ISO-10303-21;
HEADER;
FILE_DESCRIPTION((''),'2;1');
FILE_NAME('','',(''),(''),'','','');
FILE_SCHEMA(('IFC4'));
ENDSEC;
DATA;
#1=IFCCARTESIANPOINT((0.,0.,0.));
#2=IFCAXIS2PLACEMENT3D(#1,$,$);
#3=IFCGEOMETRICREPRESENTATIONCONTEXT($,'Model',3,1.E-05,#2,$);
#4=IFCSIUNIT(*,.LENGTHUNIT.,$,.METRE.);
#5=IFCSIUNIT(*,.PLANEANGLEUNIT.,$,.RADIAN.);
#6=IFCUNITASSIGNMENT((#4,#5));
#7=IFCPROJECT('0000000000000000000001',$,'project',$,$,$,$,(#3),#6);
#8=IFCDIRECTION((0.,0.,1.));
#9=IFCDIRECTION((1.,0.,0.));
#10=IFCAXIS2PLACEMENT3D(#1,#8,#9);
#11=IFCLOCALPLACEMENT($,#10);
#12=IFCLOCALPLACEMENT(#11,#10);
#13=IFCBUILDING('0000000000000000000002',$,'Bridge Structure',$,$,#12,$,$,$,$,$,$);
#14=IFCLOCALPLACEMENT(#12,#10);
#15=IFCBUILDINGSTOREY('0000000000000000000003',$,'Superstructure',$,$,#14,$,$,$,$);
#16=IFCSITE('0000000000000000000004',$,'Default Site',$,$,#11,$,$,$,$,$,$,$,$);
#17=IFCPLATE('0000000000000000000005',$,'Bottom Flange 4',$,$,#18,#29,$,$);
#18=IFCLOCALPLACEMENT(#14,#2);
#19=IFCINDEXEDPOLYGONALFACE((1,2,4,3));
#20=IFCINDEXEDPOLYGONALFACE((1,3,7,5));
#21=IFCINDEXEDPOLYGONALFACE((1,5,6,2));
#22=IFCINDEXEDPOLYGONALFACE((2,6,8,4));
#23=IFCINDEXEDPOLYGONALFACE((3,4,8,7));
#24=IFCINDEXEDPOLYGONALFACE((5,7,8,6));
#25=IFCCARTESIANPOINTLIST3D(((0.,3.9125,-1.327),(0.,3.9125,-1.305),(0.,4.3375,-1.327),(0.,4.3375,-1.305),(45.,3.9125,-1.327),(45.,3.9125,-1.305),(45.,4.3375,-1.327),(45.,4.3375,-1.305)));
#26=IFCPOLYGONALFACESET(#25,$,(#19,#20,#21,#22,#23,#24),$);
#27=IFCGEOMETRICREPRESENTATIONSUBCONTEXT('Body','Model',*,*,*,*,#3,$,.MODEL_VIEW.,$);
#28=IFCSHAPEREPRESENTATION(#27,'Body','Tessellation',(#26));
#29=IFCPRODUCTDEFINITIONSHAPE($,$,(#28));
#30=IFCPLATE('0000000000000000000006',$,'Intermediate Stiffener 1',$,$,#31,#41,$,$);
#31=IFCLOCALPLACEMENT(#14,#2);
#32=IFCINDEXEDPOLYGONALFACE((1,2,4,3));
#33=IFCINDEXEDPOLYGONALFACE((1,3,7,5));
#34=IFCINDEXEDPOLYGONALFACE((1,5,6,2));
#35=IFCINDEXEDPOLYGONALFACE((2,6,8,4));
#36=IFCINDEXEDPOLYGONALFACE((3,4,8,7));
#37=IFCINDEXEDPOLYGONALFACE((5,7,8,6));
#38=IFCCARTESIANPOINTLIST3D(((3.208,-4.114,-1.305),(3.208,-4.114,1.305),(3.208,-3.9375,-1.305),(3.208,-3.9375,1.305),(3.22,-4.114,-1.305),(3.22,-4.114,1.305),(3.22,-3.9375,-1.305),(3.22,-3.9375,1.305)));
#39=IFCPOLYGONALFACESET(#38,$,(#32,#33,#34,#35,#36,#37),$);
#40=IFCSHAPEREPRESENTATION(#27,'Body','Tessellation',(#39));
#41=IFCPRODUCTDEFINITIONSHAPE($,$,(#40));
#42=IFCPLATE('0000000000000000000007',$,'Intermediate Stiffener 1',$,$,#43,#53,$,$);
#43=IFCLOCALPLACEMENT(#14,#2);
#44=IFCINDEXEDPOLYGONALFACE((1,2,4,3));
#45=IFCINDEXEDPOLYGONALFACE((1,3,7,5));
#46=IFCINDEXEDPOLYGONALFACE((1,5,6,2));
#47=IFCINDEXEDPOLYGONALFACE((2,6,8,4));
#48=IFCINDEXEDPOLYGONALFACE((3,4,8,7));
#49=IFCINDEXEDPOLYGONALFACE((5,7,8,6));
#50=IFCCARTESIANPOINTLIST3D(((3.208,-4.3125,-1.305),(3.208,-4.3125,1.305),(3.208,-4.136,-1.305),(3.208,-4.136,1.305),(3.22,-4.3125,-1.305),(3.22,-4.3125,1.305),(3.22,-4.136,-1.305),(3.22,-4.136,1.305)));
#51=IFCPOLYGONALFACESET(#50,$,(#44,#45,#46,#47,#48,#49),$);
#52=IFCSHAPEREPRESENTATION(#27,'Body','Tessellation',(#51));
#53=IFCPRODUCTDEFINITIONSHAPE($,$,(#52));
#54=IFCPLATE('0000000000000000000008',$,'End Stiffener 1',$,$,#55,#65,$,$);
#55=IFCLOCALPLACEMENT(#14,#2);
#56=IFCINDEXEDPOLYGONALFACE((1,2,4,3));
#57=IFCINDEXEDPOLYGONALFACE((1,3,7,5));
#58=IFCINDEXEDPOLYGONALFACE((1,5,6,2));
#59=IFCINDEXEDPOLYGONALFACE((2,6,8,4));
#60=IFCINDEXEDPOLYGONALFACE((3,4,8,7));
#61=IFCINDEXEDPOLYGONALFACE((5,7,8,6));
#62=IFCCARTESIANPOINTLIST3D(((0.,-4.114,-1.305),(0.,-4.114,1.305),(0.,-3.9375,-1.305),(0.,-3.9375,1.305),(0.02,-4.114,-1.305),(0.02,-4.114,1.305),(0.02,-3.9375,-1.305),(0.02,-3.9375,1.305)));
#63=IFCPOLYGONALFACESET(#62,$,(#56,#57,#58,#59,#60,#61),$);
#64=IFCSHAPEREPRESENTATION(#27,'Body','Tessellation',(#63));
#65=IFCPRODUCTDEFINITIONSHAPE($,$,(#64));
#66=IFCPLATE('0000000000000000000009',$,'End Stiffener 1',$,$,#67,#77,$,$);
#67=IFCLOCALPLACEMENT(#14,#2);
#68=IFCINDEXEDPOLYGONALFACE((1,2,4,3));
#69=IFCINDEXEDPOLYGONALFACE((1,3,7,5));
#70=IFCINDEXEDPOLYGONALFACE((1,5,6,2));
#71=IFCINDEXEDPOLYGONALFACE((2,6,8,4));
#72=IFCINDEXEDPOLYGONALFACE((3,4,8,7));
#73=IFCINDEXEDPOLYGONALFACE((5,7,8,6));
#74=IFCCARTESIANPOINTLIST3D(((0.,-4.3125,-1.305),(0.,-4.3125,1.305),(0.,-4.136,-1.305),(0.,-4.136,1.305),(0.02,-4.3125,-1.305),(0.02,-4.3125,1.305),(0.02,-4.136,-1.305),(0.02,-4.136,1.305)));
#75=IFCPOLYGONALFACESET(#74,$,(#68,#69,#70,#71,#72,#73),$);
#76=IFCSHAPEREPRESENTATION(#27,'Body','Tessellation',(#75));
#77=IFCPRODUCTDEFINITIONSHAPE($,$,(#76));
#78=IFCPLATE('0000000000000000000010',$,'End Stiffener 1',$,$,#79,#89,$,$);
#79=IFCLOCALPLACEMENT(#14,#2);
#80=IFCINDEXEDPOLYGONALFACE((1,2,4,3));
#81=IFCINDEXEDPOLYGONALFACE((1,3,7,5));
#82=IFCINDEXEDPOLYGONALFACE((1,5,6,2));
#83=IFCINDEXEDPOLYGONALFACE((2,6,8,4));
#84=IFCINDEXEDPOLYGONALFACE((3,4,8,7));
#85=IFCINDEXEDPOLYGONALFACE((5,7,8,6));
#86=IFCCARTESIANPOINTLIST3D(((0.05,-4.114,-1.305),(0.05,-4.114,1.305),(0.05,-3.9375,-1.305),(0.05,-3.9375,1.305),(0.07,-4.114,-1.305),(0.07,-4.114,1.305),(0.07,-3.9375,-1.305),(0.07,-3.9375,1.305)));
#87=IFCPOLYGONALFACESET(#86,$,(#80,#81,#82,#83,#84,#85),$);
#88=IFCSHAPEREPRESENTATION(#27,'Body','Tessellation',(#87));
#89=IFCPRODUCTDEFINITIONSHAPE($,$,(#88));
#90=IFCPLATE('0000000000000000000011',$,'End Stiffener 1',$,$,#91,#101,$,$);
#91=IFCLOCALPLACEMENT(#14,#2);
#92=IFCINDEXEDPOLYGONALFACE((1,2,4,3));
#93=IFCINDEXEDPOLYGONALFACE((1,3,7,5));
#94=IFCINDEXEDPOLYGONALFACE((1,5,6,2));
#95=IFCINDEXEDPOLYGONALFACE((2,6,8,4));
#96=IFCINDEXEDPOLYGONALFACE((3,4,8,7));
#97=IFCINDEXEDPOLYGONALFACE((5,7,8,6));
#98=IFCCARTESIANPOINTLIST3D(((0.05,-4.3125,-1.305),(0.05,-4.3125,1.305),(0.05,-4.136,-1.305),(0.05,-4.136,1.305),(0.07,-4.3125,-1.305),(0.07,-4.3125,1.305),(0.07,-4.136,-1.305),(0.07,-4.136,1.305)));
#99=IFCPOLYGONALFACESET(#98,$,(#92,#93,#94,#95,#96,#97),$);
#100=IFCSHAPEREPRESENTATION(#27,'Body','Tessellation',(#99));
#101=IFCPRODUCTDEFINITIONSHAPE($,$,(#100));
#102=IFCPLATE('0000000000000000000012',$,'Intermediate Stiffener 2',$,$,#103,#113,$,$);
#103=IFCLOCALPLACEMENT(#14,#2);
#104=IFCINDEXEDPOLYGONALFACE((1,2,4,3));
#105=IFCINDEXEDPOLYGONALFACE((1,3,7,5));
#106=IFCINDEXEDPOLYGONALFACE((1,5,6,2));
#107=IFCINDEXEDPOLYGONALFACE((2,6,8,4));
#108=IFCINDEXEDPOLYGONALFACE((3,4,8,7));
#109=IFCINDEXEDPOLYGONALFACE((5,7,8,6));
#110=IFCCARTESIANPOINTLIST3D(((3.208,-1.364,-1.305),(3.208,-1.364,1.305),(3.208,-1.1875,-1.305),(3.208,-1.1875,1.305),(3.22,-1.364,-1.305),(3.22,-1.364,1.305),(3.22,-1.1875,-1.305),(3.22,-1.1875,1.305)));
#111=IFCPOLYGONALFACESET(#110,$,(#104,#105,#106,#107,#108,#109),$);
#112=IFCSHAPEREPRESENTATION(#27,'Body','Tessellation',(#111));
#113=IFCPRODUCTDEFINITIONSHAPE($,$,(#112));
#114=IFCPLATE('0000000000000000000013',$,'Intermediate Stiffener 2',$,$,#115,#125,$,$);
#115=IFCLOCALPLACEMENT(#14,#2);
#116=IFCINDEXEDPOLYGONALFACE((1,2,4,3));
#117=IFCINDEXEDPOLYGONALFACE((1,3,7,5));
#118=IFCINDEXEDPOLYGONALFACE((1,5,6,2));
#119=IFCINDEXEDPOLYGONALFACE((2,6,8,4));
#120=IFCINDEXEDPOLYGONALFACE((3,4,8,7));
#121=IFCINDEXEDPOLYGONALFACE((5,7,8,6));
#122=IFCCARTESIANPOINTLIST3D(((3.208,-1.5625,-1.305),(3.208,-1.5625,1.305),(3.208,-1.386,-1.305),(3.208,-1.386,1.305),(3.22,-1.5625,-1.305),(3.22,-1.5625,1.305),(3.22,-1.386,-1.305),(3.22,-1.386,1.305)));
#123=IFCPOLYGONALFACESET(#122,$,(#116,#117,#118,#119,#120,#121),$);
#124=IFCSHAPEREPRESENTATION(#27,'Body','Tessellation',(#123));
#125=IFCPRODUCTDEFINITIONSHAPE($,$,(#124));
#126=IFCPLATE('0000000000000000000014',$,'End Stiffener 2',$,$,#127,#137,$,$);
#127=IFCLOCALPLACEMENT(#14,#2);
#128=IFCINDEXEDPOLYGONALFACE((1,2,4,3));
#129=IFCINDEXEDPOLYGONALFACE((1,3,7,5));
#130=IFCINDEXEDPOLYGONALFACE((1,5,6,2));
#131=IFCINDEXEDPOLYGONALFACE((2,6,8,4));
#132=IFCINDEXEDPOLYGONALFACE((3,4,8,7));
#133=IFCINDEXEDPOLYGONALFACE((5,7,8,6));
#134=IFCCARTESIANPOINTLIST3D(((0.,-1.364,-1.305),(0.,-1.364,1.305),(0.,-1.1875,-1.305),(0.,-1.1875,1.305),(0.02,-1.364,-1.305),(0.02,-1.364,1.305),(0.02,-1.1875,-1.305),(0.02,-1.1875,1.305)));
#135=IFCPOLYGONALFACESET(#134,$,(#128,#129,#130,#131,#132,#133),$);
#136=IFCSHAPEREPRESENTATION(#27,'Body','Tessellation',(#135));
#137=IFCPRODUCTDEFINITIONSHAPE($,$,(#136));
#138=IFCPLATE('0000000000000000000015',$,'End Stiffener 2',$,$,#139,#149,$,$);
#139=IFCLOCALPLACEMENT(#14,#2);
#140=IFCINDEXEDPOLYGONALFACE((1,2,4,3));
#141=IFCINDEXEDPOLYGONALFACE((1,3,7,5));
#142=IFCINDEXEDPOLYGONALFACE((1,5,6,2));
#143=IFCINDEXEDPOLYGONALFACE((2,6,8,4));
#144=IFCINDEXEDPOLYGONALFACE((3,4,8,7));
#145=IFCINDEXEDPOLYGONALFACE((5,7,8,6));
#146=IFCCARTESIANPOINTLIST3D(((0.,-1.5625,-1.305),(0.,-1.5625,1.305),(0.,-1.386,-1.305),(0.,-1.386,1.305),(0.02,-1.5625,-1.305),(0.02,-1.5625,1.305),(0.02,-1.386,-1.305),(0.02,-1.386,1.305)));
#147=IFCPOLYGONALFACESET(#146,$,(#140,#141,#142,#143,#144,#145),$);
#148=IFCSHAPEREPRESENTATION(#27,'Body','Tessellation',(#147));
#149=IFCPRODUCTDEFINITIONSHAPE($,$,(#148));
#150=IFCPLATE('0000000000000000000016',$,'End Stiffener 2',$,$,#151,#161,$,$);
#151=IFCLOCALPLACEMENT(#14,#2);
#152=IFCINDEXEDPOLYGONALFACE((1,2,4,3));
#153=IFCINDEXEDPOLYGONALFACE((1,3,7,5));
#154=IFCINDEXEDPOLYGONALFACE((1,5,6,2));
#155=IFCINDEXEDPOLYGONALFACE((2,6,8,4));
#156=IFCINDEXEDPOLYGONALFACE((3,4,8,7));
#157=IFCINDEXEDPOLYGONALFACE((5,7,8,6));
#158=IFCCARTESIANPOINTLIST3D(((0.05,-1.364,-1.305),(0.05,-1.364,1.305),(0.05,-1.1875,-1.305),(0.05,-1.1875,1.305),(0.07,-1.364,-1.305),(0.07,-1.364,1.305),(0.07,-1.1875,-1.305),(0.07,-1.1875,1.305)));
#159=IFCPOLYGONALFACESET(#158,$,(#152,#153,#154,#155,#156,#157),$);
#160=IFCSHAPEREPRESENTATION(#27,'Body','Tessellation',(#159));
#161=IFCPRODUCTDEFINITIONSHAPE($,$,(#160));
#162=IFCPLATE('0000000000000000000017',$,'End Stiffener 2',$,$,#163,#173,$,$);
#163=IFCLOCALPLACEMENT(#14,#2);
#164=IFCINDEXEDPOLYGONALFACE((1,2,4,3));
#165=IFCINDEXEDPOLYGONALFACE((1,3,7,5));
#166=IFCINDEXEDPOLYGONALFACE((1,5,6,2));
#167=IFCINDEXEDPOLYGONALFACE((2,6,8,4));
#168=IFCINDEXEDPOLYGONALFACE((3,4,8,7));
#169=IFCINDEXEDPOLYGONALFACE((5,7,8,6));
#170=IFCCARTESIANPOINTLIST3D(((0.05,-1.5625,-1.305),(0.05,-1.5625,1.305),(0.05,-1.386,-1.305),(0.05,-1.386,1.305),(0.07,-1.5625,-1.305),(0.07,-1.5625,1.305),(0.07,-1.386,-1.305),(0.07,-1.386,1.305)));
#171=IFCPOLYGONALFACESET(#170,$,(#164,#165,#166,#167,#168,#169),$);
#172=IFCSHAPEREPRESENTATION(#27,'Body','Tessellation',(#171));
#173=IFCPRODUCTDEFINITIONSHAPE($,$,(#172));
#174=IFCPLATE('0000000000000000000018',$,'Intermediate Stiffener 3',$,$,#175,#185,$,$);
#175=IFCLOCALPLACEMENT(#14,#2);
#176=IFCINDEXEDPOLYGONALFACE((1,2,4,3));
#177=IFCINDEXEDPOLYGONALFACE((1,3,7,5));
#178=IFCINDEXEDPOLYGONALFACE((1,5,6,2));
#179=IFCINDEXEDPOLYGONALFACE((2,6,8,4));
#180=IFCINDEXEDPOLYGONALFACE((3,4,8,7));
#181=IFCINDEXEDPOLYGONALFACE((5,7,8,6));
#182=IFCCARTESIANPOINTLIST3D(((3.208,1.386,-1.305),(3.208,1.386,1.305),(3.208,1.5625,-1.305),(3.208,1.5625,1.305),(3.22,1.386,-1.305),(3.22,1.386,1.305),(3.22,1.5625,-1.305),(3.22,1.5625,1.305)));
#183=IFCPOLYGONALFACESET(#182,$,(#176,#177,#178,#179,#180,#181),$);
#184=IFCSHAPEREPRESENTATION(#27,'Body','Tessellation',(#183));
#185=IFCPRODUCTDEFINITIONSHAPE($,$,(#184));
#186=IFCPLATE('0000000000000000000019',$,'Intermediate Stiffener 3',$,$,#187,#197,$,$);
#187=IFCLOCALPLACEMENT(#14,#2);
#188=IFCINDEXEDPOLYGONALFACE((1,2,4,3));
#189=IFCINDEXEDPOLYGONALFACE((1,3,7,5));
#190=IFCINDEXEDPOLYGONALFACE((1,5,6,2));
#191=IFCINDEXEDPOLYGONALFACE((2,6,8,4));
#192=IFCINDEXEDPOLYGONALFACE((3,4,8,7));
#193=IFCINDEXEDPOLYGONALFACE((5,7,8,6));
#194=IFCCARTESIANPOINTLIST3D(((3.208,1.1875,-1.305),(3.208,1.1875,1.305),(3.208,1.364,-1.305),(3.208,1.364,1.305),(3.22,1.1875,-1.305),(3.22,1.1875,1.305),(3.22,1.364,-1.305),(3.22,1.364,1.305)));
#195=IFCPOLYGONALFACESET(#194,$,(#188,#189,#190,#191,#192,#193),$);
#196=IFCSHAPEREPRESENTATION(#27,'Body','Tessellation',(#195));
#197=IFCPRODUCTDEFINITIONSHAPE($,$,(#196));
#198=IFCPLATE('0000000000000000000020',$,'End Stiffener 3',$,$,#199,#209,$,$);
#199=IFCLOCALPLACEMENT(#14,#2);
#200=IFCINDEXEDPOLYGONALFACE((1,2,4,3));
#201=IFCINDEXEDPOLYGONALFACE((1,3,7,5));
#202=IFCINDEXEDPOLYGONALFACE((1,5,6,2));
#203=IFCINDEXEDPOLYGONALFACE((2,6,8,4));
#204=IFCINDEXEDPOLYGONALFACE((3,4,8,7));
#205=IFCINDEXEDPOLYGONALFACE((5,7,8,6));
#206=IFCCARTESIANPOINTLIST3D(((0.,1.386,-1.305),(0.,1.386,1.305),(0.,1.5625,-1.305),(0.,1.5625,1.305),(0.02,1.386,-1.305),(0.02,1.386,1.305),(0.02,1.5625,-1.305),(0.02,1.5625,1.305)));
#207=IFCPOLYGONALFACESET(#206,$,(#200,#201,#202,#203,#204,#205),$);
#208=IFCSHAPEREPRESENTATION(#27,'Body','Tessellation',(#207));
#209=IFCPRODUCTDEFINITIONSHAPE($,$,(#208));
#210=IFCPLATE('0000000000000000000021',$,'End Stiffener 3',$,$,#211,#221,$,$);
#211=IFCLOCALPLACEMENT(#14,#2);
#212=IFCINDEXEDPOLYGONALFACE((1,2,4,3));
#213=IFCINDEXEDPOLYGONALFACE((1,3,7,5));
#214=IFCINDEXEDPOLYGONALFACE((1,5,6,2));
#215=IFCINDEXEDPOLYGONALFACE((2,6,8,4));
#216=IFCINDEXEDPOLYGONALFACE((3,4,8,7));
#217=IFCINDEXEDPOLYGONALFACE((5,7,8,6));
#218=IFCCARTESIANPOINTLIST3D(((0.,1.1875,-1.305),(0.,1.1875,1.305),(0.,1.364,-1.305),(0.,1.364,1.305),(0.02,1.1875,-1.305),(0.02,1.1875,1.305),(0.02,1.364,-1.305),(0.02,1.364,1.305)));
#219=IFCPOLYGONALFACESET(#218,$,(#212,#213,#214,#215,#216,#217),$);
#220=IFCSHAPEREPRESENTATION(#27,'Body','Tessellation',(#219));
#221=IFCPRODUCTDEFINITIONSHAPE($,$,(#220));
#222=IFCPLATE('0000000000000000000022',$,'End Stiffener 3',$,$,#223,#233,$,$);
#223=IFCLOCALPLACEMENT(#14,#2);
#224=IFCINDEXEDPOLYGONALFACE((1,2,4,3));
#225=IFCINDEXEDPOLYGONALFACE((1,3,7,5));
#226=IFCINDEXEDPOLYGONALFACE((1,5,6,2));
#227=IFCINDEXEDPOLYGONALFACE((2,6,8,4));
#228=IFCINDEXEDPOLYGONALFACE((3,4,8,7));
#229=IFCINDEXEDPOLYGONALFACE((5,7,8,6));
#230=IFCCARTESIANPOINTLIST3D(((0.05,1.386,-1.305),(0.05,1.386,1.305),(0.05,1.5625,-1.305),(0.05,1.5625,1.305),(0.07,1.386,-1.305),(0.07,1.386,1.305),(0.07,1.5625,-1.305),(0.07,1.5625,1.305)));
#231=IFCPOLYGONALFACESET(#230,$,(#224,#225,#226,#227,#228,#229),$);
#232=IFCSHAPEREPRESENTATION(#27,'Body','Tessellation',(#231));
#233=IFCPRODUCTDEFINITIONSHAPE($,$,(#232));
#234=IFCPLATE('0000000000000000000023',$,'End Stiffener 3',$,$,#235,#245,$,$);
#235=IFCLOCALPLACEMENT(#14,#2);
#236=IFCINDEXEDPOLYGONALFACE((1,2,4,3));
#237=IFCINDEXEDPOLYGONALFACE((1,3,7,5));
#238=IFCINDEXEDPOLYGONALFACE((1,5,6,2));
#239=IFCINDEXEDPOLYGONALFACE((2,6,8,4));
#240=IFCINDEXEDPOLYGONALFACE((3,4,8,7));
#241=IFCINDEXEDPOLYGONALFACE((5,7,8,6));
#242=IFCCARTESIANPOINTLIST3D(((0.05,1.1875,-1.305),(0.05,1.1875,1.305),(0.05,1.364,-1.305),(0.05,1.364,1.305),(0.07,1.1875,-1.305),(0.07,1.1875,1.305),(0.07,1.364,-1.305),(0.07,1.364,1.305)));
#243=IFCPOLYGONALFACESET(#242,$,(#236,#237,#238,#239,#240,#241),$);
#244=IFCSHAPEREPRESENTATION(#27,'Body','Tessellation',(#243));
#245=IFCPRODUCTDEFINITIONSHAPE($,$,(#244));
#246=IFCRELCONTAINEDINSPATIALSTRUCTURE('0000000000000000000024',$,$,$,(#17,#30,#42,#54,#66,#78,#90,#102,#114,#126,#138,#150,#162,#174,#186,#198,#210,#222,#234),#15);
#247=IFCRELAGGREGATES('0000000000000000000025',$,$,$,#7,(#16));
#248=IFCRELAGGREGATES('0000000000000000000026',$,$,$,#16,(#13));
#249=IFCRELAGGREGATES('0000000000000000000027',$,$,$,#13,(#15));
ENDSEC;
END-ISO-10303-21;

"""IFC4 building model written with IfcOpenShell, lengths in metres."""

from ifc_helpers import new_model, si_unit, frame, origin, origin_with_axes, origin_2d_with_axis, place, context, subcontext, project, spatial, rectangle, extrude, element, save


model = new_model("IFC4")

# Units and contexts
model_context = context("Model", 3, precision=1e-05, world=origin())
body_context = subcontext(model_context, "Body", "Model", "MODEL_VIEW")
ifc_project = project(units=[si_unit("LENGTHUNIT", "METRE"), si_unit("PLANEANGLEUNIT", "RADIAN")], contexts=[model_context])

# Site, building, storey
site_placement = place(None, origin_with_axes())
site = spatial("IfcSite", under=ifc_project, at=site_placement, Name="Default Site")
building_placement = place(site_placement, origin_with_axes())
building = spatial("IfcBuilding", under=site, at=building_placement, Name="Bridge Structure")
storey_placement = place(building_placement, origin_with_axes())
storey = spatial("IfcBuildingStorey", under=building, at=storey_placement, Name="Superstructure")

# Plates
plate_1_placement = place(storey_placement, frame((0.0, 4.125, -1.316), z_axis=(1.0, 0.0, 0.0), x_axis=(0.0, 1.0, 0.0)))
element("IfcPlate", 1, at=plate_1_placement, inside=storey, Name="Bottom Flange 4", context=body_context, shape_type="SweptSolid", body=[
    extrude(rectangle(XDim=0.425, YDim=0.022, at=origin_2d_with_axis()), origin_with_axes(), (0.0, 0.0, 1.0), 45.0),
])
for number, where, z_axis, x_axis, name in (
    (2, (3.214, -4.0258, -1.305), (0.0, 0.0, 1.0), (1.0, 0.0, 0.0), "Intermediate Stiffener 1"),
    (3, (3.214, -4.2243, -1.305), (0.0, 0.0, 1.0), (1.0, 0.0, 0.0), "Intermediate Stiffener 1"),
):
    element("IfcPlate", number, at=place(storey_placement, frame(where, z_axis=z_axis, x_axis=x_axis)), inside=storey, Name=name, context=body_context, shape_type="SweptSolid", body=[
        extrude(rectangle(XDim=0.012, YDim=0.1765, at=origin_2d_with_axis()), origin_with_axes(), (0.0, 0.0, 1.0), 2.61),
    ])
for number, where, z_axis, x_axis, name in (
    (4, (0.01, -4.0258, -1.305), (0.0, 0.0, 1.0), (1.0, 0.0, 0.0), "End Stiffener 1"),
    (5, (0.01, -4.2243, -1.305), (0.0, 0.0, 1.0), (1.0, 0.0, 0.0), "End Stiffener 1"),
    (6, (0.06, -4.0258, -1.305), (0.0, 0.0, 1.0), (1.0, 0.0, 0.0), "End Stiffener 1"),
    (7, (0.06, -4.2243, -1.305), (0.0, 0.0, 1.0), (1.0, 0.0, 0.0), "End Stiffener 1"),
):
    element("IfcPlate", number, at=place(storey_placement, frame(where, z_axis=z_axis, x_axis=x_axis)), inside=storey, Name=name, context=body_context, shape_type="SweptSolid", body=[
        extrude(rectangle(XDim=0.02, YDim=0.1765, at=origin_2d_with_axis()), origin_with_axes(), (0.0, 0.0, 1.0), 2.61),
    ])
for number, where, z_axis, x_axis, name in (
    (8, (3.214, -1.2757, -1.305), (0.0, 0.0, 1.0), (1.0, 0.0, 0.0), "Intermediate Stiffener 2"),
    (9, (3.214, -1.4743, -1.305), (0.0, 0.0, 1.0), (1.0, 0.0, 0.0), "Intermediate Stiffener 2"),
):
    element("IfcPlate", number, at=place(storey_placement, frame(where, z_axis=z_axis, x_axis=x_axis)), inside=storey, Name=name, context=body_context, shape_type="SweptSolid", body=[
        extrude(rectangle(XDim=0.012, YDim=0.1765, at=origin_2d_with_axis()), origin_with_axes(), (0.0, 0.0, 1.0), 2.61),
    ])
for number, where, z_axis, x_axis, name in (
    (10, (0.01, -1.2757, -1.305), (0.0, 0.0, 1.0), (1.0, 0.0, 0.0), "End Stiffener 2"),
    (11, (0.01, -1.4743, -1.305), (0.0, 0.0, 1.0), (1.0, 0.0, 0.0), "End Stiffener 2"),
    (12, (0.06, -1.2757, -1.305), (0.0, 0.0, 1.0), (1.0, 0.0, 0.0), "End Stiffener 2"),
    (13, (0.06, -1.4743, -1.305), (0.0, 0.0, 1.0), (1.0, 0.0, 0.0), "End Stiffener 2"),
):
    element("IfcPlate", number, at=place(storey_placement, frame(where, z_axis=z_axis, x_axis=x_axis)), inside=storey, Name=name, context=body_context, shape_type="SweptSolid", body=[
        extrude(rectangle(XDim=0.02, YDim=0.1765, at=origin_2d_with_axis()), origin_with_axes(), (0.0, 0.0, 1.0), 2.61),
    ])
for number, where, z_axis, x_axis, name in (
    (14, (3.214, 1.4743, -1.305), (0.0, 0.0, 1.0), (1.0, 0.0, 0.0), "Intermediate Stiffener 3"),
    (15, (3.214, 1.2757, -1.305), (0.0, 0.0, 1.0), (1.0, 0.0, 0.0), "Intermediate Stiffener 3"),
):
    element("IfcPlate", number, at=place(storey_placement, frame(where, z_axis=z_axis, x_axis=x_axis)), inside=storey, Name=name, context=body_context, shape_type="SweptSolid", body=[
        extrude(rectangle(XDim=0.012, YDim=0.1765, at=origin_2d_with_axis()), origin_with_axes(), (0.0, 0.0, 1.0), 2.61),
    ])
for number, where, z_axis, x_axis, name in (
    (16, (0.01, 1.4743, -1.305), (0.0, 0.0, 1.0), (1.0, 0.0, 0.0), "End Stiffener 3"),
    (17, (0.01, 1.2757, -1.305), (0.0, 0.0, 1.0), (1.0, 0.0, 0.0), "End Stiffener 3"),
    (18, (0.06, 1.4743, -1.305), (0.0, 0.0, 1.0), (1.0, 0.0, 0.0), "End Stiffener 3"),
    (19, (0.06, 1.2757, -1.305), (0.0, 0.0, 1.0), (1.0, 0.0, 0.0), "End Stiffener 3"),
):
    element("IfcPlate", number, at=place(storey_placement, frame(where, z_axis=z_axis, x_axis=x_axis)), inside=storey, Name=name, context=body_context, shape_type="SweptSolid", body=[
        extrude(rectangle(XDim=0.02, YDim=0.1765, at=origin_2d_with_axis()), origin_with_axes(), (0.0, 0.0, 1.0), 2.61),
    ])

save(model, "model.ifc")
